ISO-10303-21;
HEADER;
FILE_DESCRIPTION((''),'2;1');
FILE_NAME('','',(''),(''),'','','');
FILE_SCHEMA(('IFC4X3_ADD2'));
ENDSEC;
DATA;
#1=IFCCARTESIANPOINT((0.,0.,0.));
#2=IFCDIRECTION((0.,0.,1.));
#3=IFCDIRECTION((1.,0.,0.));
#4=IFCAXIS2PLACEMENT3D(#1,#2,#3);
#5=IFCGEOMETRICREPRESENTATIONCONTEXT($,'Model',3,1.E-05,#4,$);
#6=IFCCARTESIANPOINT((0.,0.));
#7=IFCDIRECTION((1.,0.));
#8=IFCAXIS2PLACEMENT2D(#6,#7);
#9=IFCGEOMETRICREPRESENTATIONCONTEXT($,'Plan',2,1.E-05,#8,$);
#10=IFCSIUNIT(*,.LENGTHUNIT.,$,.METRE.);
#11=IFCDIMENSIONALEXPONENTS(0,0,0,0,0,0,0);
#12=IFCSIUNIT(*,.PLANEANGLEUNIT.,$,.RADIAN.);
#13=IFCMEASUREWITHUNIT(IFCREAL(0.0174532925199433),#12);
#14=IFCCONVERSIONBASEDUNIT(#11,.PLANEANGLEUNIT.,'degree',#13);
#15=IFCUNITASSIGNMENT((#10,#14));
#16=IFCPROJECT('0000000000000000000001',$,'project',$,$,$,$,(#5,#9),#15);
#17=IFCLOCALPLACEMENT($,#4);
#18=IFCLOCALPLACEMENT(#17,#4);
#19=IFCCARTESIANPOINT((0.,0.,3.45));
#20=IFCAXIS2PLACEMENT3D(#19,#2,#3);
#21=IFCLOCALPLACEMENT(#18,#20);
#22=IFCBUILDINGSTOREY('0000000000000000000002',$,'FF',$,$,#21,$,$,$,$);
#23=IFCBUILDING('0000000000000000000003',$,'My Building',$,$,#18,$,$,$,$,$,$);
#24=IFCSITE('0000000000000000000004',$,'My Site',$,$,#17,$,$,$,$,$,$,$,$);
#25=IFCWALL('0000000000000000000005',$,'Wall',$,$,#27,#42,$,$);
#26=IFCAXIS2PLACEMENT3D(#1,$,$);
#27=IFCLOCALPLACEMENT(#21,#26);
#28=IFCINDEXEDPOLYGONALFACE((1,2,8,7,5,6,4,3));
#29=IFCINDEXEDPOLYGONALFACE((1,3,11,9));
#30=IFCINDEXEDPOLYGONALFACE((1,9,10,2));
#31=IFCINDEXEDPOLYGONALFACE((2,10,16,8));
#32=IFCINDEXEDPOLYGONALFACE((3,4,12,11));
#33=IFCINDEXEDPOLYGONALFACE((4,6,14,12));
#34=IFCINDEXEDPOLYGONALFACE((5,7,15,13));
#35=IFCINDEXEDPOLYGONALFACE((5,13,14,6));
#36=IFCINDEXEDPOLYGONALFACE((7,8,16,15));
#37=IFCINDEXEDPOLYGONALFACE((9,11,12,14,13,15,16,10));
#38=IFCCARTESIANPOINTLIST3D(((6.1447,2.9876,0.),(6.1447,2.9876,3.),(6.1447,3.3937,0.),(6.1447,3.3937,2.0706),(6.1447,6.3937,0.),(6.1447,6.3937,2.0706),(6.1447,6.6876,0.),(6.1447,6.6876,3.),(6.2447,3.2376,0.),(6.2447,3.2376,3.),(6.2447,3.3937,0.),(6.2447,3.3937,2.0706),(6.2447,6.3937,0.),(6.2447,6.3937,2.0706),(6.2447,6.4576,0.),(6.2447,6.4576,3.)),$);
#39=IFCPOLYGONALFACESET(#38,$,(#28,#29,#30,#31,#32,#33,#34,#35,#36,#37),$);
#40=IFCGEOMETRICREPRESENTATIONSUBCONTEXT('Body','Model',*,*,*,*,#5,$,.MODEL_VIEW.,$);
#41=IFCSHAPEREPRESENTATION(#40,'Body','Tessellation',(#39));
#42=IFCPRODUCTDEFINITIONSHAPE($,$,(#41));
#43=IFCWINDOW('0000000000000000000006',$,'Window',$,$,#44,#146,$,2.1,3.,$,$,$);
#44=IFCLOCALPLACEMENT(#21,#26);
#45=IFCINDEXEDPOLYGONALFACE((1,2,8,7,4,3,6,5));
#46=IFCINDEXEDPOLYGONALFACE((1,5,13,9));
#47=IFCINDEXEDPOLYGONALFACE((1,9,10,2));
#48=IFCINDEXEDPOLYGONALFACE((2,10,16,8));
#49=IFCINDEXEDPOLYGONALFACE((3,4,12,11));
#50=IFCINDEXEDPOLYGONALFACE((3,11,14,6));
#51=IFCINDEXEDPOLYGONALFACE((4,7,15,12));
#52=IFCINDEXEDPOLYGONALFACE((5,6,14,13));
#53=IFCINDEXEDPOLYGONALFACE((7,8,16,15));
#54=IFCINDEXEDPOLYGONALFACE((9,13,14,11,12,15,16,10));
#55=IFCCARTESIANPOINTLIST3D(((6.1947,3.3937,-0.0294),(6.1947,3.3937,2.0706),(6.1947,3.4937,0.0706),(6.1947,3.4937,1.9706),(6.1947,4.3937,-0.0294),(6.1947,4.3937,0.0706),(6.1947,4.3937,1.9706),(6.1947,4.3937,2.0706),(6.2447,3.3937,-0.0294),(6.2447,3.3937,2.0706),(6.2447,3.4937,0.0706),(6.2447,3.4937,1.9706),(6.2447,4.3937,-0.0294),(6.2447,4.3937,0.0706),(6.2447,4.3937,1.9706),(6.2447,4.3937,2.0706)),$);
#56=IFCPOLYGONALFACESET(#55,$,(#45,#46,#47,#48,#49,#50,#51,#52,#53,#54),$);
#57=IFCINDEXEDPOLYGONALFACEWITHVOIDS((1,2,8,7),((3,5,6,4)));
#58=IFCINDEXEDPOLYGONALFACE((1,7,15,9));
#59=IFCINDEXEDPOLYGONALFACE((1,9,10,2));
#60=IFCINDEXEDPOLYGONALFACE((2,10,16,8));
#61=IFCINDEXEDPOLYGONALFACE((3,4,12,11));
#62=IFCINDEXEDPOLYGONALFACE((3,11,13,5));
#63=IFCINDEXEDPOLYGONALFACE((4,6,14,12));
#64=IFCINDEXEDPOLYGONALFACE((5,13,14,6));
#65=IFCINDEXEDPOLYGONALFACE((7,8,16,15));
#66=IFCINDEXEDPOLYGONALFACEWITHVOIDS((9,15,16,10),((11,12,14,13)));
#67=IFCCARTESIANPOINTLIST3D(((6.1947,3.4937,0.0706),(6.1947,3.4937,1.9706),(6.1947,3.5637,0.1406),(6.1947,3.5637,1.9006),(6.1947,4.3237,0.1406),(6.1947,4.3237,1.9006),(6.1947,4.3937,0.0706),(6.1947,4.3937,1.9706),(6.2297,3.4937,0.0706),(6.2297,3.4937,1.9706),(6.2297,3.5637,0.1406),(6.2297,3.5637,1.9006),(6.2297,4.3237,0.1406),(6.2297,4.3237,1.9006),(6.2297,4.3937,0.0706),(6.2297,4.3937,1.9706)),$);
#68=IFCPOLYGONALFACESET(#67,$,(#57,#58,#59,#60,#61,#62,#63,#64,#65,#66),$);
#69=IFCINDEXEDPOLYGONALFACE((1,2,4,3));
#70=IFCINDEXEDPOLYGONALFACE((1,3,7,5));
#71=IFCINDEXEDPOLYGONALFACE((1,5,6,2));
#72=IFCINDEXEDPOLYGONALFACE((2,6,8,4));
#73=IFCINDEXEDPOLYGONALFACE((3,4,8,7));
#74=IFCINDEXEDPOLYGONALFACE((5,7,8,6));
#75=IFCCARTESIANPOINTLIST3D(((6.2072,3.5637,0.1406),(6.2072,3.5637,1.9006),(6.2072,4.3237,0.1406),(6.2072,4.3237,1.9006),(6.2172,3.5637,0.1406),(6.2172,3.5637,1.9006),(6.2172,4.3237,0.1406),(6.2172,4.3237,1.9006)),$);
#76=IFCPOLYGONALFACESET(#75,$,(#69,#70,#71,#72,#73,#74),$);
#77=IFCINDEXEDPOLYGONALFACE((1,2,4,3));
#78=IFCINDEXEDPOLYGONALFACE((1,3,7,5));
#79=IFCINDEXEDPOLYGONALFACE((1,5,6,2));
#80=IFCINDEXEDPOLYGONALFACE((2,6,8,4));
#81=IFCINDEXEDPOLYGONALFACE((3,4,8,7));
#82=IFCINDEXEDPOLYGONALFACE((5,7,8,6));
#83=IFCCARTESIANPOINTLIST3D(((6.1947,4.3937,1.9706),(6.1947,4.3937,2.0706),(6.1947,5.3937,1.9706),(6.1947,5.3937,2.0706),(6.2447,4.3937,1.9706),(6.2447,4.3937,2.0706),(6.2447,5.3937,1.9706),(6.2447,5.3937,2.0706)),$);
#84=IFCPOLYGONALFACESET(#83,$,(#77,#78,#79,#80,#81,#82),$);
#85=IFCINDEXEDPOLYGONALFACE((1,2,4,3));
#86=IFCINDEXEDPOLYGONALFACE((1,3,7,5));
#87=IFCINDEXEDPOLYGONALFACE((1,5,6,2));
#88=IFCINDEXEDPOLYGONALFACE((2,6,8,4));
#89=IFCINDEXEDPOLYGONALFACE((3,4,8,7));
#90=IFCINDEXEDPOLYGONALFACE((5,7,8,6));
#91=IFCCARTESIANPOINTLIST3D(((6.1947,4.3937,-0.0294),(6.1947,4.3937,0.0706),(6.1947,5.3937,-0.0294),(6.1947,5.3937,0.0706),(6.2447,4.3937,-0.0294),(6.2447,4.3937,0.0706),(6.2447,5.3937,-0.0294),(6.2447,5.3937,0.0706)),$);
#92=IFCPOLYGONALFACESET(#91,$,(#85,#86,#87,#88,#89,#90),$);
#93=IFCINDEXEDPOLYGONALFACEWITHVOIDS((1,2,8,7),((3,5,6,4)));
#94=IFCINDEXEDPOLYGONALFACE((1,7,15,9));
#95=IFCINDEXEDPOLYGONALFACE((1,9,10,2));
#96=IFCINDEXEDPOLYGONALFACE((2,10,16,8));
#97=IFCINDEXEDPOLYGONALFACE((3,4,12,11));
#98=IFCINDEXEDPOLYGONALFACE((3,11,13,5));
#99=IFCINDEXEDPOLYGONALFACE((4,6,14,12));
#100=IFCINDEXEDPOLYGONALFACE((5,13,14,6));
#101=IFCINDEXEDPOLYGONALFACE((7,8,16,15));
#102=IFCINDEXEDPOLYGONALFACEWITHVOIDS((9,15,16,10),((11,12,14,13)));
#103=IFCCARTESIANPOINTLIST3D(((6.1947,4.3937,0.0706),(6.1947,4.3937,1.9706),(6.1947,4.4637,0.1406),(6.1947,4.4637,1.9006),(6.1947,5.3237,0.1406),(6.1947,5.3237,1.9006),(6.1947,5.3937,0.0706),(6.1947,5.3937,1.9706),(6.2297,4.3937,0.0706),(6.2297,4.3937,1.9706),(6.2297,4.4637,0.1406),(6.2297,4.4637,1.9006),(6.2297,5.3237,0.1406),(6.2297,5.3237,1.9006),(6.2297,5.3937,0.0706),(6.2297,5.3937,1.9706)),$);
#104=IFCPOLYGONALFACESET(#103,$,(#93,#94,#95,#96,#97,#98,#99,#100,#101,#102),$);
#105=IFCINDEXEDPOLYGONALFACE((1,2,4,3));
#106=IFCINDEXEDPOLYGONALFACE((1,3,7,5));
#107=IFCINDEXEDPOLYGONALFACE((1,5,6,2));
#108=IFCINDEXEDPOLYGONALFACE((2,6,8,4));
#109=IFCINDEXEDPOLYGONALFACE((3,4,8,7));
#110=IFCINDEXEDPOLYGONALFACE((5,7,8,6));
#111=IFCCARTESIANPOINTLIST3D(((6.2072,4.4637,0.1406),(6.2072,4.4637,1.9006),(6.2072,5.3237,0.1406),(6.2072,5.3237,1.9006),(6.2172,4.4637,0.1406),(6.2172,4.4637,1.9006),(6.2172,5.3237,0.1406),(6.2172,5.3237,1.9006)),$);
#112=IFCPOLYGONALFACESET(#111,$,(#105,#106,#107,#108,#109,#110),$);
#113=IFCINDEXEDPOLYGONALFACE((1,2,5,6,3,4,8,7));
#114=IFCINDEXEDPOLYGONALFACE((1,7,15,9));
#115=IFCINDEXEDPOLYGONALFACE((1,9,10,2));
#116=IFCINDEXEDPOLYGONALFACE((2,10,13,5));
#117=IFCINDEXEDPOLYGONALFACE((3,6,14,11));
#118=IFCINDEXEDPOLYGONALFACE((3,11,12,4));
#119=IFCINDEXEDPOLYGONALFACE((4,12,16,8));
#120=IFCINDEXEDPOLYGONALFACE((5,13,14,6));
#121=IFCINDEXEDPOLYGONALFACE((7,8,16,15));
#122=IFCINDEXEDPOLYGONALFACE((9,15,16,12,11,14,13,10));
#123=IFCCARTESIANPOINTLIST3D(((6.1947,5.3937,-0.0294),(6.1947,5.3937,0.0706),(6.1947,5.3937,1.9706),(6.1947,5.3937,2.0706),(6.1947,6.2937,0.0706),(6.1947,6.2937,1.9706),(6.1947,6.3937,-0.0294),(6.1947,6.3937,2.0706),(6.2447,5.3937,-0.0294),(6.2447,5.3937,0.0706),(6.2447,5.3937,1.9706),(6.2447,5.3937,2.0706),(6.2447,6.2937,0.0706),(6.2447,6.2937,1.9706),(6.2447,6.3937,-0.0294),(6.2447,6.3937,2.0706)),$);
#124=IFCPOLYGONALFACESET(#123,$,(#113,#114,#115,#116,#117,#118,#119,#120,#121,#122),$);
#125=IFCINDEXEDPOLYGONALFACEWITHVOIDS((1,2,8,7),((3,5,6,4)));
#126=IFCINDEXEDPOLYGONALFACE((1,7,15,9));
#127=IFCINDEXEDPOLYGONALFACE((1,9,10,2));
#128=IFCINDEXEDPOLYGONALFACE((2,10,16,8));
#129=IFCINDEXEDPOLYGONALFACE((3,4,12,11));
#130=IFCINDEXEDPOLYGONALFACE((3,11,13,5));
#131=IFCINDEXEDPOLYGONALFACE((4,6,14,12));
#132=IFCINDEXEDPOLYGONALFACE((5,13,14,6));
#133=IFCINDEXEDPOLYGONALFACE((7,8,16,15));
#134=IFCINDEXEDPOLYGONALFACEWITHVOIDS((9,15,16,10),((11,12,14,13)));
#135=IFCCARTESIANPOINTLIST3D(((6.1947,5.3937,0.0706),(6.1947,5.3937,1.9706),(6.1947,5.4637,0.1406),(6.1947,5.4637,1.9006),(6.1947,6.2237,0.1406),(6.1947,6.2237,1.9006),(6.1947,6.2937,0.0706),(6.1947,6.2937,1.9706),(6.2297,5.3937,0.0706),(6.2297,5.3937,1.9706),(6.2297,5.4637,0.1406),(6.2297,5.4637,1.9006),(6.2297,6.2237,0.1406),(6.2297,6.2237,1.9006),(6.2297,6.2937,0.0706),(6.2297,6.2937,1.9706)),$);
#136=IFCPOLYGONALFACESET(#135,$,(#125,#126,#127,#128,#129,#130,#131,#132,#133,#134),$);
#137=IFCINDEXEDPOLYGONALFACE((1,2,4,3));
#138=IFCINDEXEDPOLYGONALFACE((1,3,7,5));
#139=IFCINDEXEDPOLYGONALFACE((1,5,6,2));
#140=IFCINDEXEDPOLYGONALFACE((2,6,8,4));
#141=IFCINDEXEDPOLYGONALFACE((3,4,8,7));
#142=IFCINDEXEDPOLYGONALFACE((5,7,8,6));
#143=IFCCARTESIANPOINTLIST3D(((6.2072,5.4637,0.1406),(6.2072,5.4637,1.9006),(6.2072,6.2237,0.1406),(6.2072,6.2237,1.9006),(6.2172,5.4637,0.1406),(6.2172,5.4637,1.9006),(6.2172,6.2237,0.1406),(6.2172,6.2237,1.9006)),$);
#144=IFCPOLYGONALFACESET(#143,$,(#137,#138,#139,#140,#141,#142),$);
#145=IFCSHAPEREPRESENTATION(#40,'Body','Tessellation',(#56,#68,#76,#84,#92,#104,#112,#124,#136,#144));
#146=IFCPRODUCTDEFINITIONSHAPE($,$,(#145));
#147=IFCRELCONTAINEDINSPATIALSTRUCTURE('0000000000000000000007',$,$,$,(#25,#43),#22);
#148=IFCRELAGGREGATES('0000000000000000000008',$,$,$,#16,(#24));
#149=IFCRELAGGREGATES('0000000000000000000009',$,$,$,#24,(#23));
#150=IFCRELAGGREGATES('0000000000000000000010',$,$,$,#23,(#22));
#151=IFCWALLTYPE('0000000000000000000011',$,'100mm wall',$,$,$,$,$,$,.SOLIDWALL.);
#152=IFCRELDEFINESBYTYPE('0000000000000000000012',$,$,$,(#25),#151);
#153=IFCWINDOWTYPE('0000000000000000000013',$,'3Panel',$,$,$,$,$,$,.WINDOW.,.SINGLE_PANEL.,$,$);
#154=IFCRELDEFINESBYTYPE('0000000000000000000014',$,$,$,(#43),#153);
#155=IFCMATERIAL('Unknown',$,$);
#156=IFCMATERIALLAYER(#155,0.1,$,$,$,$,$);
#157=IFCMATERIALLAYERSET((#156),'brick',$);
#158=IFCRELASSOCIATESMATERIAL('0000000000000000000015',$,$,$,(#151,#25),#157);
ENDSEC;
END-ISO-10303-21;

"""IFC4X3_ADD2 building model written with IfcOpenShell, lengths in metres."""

from ifc_helpers import new_model, entity, si_unit, converted_unit, frame, origin_with_axes, origin_2d_with_axis, place, context, subcontext, project, spatial, line, indexed_curve, outline, extrude, shape, source, transform, mapped, material, layer, layer_set, layer_usage, type_object, type_shapes, element, fill, save


model = new_model("IFC4X3_ADD2")

# Units and contexts
model_context = context("Model", 3, precision=1e-05, world=origin_with_axes())
plan_context = context("Plan", 2, precision=1e-05, world=origin_2d_with_axis())
body_context_1 = subcontext(model_context, "Body", "Model", "MODEL_VIEW")
body_context_2 = subcontext(plan_context, "Body", "Plan", "PLAN_VIEW")
ifc_project = project(units=[si_unit("LENGTHUNIT", "METRE"), converted_unit("PLANEANGLEUNIT", "degree", entity("IfcReal", 0.0174532925199433), si_unit("PLANEANGLEUNIT", "RADIAN"), dimensions=[0, 0, 0, 0, 0, 0, 0])], contexts=[model_context, plan_context])

# Site, building, storey
site_placement = place(None, origin_with_axes())
site = spatial("IfcSite", under=ifc_project, at=site_placement, Name="My Site")
building_placement = place(site_placement, origin_with_axes())
building = spatial("IfcBuilding", under=site, at=building_placement, Name="My Building")
storey_placement = place(building_placement, frame((0.0, 0.0, 3.45), z_axis=(0.0, 0.0, 1.0), x_axis=(1.0, 0.0, 0.0)))
storey = spatial("IfcBuildingStorey", under=building, at=storey_placement, Name="FF")

# Shared definitions
ifc_material = material(Name="Unknown")

# Shared definitions
ifc_layer_1 = layer(ifc_material, 0.1)
ifc_layer_set_1 = layer_set([ifc_layer_1], Name="brick")
wall_type_1 = type_object("IfcWallType", Name="100mm wall", PredefinedType="SOLIDWALL", material=ifc_layer_set_1)

# Wall, opening, window
ifc_layer_usage_1 = layer_usage(ifc_layer_set_1, "AXIS2", "POSITIVE", 0.0)
wall_1_placement = place(storey_placement, frame((6.2447, 2.9876, 0.0), z_axis=(0.0, 0.0, 1.0), x_axis=(0.0, 1.0, 0.0)))
wall_1 = element("IfcWall", 1, at=wall_1_placement, inside=storey, type_object=wall_type_1, material=ifc_layer_usage_1, Name="Wall", context=body_context_1, shape_type="SweptSolid", body=[
    extrude(outline(indexed_curve([(0.25, 0.0), (0.0, 0.1), (3.7, 0.1), (3.47, 0.0)], segments=[line(1, 2, 3, 4, 1)])), origin_with_axes(), (0.0, 0.0, 1.0), 3.0),
])
shared_shape_1 = source(origin_with_axes(), body_context_1, "Body", "SweptSolid", [
    extrude(outline(indexed_curve([(0.0, 0.0), (3.0, 0.0), (3.0, 2.1), (0.0, 2.1)], segments=[line(1, 2, 3, 4, 1)])), frame((0.0, -0.6, 0.0), z_axis=(0.0, -1.0, 0.0), x_axis=(1.0, 0.0, 0.0)), (0.0, 0.0, -1.0), 1.2),
])
opening_1_placement = place(wall_1_placement, frame((0.4061, 0.0, -0.0294), z_axis=(0.0, 0.0, 1.0), x_axis=(1.0, 0.0, 0.0)))
opening_1 = element("IfcOpeningElement", 2, at=opening_1_placement, cuts=wall_1, PredefinedType="OPENING", context=body_context_1, shape_type="MappedRepresentation", body=[
    mapped(shared_shape_1, transform((0.0, 0.0, 0.0), x_axis=(1.0, 0.0, 0.0), y_axis=(0.0, 1.0, 0.0), z_axis=(0.0, 0.0, 1.0), scale=1.0)),
])
window_type = type_object("IfcWindowType", Name="3Panel", PartitioningType="SINGLE_PANEL", PredefinedType="WINDOW")
shared_shape_2 = source(origin_with_axes(), body_context_1, "Body", "SweptSolid", [
    extrude(outline(indexed_curve([(1.0, 0.0), (0.0, 0.0), (0.0, 2.1), (1.0, 2.1), (1.0, 2.0), (0.1, 2.0), (0.1, 0.1), (1.0, 0.1)], segments=[line(1, 2, 3, 4, 5, 6, 7, 8, 1)])), frame((0.0, 0.0, 0.0), z_axis=(0.0, -1.0, 0.0), x_axis=(1.0, 0.0, 0.0)), (0.0, 0.0, -1.0), 0.05),
    extrude(outline(indexed_curve([(0.0, 0.0), (0.9, 0.0), (0.9, 1.9), (0.0, 1.9)], segments=[line(1, 2, 3, 4, 1)]), holes=[indexed_curve([(0.07, 0.07), (0.83, 0.07), (0.83, 1.83), (0.07, 1.83)], segments=[line(1, 2, 3, 4, 1)])]), frame((0.1, 0.015, 0.1), z_axis=(0.0, -1.0, 0.0), x_axis=(1.0, 0.0, 0.0)), (0.0, 0.0, -1.0), 0.035),
    extrude(outline(indexed_curve([(0.07, 0.07), (0.83, 0.07), (0.83, 1.83), (0.07, 1.83)], segments=[line(1, 2, 3, 4, 1)])), frame((0.1, 0.0275, 0.1), z_axis=(0.0, -1.0, 0.0), x_axis=(1.0, 0.0, 0.0)), (0.0, 0.0, -1.0), 0.01),
    extrude(outline(indexed_curve([(0.0, 2.1), (1.0, 2.1), (1.0, 2.0), (0.0, 2.0)], segments=[line(1, 2, 3, 4, 1)])), frame((1.0, 0.0, 0.0), z_axis=(0.0, -1.0, 0.0), x_axis=(1.0, 0.0, 0.0)), (0.0, 0.0, -1.0), 0.05),
    extrude(outline(indexed_curve([(1.0, 0.0), (0.0, 0.0), (0.0, 0.1), (1.0, 0.1)], segments=[line(1, 2, 3, 4, 1)])), frame((1.0, 0.0, 0.0), z_axis=(0.0, -1.0, 0.0), x_axis=(1.0, 0.0, 0.0)), (0.0, 0.0, -1.0), 0.05),
    extrude(outline(indexed_curve([(0.0, 0.0), (1.0, 0.0), (1.0, 1.9), (0.0, 1.9)], segments=[line(1, 2, 3, 4, 1)]), holes=[indexed_curve([(0.07, 0.07), (0.93, 0.07), (0.93, 1.83), (0.07, 1.83)], segments=[line(1, 2, 3, 4, 1)])]), frame((1.0, 0.015, 0.1), z_axis=(0.0, -1.0, 0.0), x_axis=(1.0, 0.0, 0.0)), (0.0, 0.0, -1.0), 0.035),
    extrude(outline(indexed_curve([(0.07, 0.07), (0.93, 0.07), (0.93, 1.83), (0.07, 1.83)], segments=[line(1, 2, 3, 4, 1)])), frame((1.0, 0.0275, 0.1), z_axis=(0.0, -1.0, 0.0), x_axis=(1.0, 0.0, 0.0)), (0.0, 0.0, -1.0), 0.01),
    extrude(outline(indexed_curve([(0.0, 2.1), (1.0, 2.1), (1.0, 0.0), (0.0, 0.0), (0.0, 0.1), (0.9, 0.1), (0.9, 2.0), (0.0, 2.0)], segments=[line(1, 2, 3, 4, 5, 6, 7, 8, 1)])), frame((2.0, 0.0, 0.0), z_axis=(0.0, -1.0, 0.0), x_axis=(1.0, 0.0, 0.0)), (0.0, 0.0, -1.0), 0.05),
    extrude(outline(indexed_curve([(0.0, 0.0), (0.9, 0.0), (0.9, 1.9), (0.0, 1.9)], segments=[line(1, 2, 3, 4, 1)]), holes=[indexed_curve([(0.07, 0.07), (0.83, 0.07), (0.83, 1.83), (0.07, 1.83)], segments=[line(1, 2, 3, 4, 1)])]), frame((2.0, 0.015, 0.1), z_axis=(0.0, -1.0, 0.0), x_axis=(1.0, 0.0, 0.0)), (0.0, 0.0, -1.0), 0.035),
    extrude(outline(indexed_curve([(0.07, 0.07), (0.83, 0.07), (0.83, 1.83), (0.07, 1.83)], segments=[line(1, 2, 3, 4, 1)])), frame((2.0, 0.0275, 0.1), z_axis=(0.0, -1.0, 0.0), x_axis=(1.0, 0.0, 0.0)), (0.0, 0.0, -1.0), 0.01),
])
shared_shape_3 = source(origin_with_axes(), body_context_2, "Body", "Curve2D", [
    entity("IfcIndexedPolyCurve", entity("IfcCartesianPointList2D", [[0.1, 0.0], [1.0, 0.0]])),
    entity("IfcIndexedPolyCurve", entity("IfcCartesianPointList2D", [[0.0, 0.05], [0.1, 0.05], [0.1, 0.0], [0.0, 0.0]]), [entity("IfcLineIndex", [1, 2, 3, 4, 1])]),
    entity("IfcIndexedPolyCurve", entity("IfcCartesianPointList2D", [[1.0, 0.05], [1.0, 0.05], [1.0, 0.0], [1.0, 0.0]])),
    entity("IfcIndexedPolyCurve", entity("IfcCartesianPointList2D", [[0.1, 0.015], [0.17, 0.015], [0.17, 0.05], [0.1, 0.05]]), [entity("IfcLineIndex", [1, 2, 3, 4, 1])]),
    entity("IfcIndexedPolyCurve", entity("IfcCartesianPointList2D", [[1.0, 0.015], [0.93, 0.015], [0.93, 0.05], [1.0, 0.05]]), [entity("IfcLineIndex", [1, 2, 3, 4, 1])]),
    entity("IfcIndexedPolyCurve", entity("IfcCartesianPointList2D", [[0.17, 0.015], [0.93, 0.015]])),
    entity("IfcIndexedPolyCurve", entity("IfcCartesianPointList2D", [[0.17, 0.05], [0.93, 0.05]])),
    entity("IfcIndexedPolyCurve", entity("IfcCartesianPointList2D", [[0.17, 0.0325], [0.93, 0.0325]])),
    entity("IfcIndexedPolyCurve", entity("IfcCartesianPointList2D", [[1.0, 0.0], [2.0, 0.0]])),
    entity("IfcIndexedPolyCurve", entity("IfcCartesianPointList2D", [[1.0, 0.05], [1.0, 0.05], [1.0, 0.0], [1.0, 0.0]])),
    entity("IfcIndexedPolyCurve", entity("IfcCartesianPointList2D", [[2.0, 0.05], [2.0, 0.05], [2.0, 0.0], [2.0, 0.0]])),
    entity("IfcIndexedPolyCurve", entity("IfcCartesianPointList2D", [[1.0, 0.015], [1.07, 0.015], [1.07, 0.05], [1.0, 0.05]]), [entity("IfcLineIndex", [1, 2, 3, 4, 1])]),
    entity("IfcIndexedPolyCurve", entity("IfcCartesianPointList2D", [[2.0, 0.015], [1.93, 0.015], [1.93, 0.05], [2.0, 0.05]]), [entity("IfcLineIndex", [1, 2, 3, 4, 1])]),
    entity("IfcIndexedPolyCurve", entity("IfcCartesianPointList2D", [[1.07, 0.015], [1.93, 0.015]])),
    entity("IfcIndexedPolyCurve", entity("IfcCartesianPointList2D", [[1.07, 0.05], [1.93, 0.05]])),
    entity("IfcIndexedPolyCurve", entity("IfcCartesianPointList2D", [[1.07, 0.0325], [1.93, 0.0325]])),
    entity("IfcIndexedPolyCurve", entity("IfcCartesianPointList2D", [[2.0, 0.0], [2.9, 0.0]])),
    entity("IfcIndexedPolyCurve", entity("IfcCartesianPointList2D", [[2.0, 0.05], [2.0, 0.05], [2.0, 0.0], [2.0, 0.0]])),
    entity("IfcIndexedPolyCurve", entity("IfcCartesianPointList2D", [[3.0, 0.05], [2.9, 0.05], [2.9, 0.0], [3.0, 0.0]]), [entity("IfcLineIndex", [1, 2, 3, 4, 1])]),
    entity("IfcIndexedPolyCurve", entity("IfcCartesianPointList2D", [[2.0, 0.015], [2.07, 0.015], [2.07, 0.05], [2.0, 0.05]]), [entity("IfcLineIndex", [1, 2, 3, 4, 1])]),
    entity("IfcIndexedPolyCurve", entity("IfcCartesianPointList2D", [[2.9, 0.015], [2.83, 0.015], [2.83, 0.05], [2.9, 0.05]]), [entity("IfcLineIndex", [1, 2, 3, 4, 1])]),
    entity("IfcIndexedPolyCurve", entity("IfcCartesianPointList2D", [[2.07, 0.015], [2.83, 0.015]])),
    entity("IfcIndexedPolyCurve", entity("IfcCartesianPointList2D", [[2.07, 0.05], [2.83, 0.05]])),
    entity("IfcIndexedPolyCurve", entity("IfcCartesianPointList2D", [[2.07, 0.0325], [2.83, 0.0325]])),
])
type_shapes(window_type, [shared_shape_2, shared_shape_3])
window_placement = place(opening_1_placement, frame((0.0, 0.0, 0.0), z_axis=(0.0, 0.0, 1.0), x_axis=(1.0, 0.0, 0.0)))
window = element("IfcWindow", 3, at=window_placement, inside=storey, type_object=window_type, Name="Window", OverallHeight=2.1, OverallWidth=3.0, shapes=[
    shape(body_context_1, "Body", "MappedRepresentation", [mapped(shared_shape_2, transform((0.0, 0.0, 0.0), x_axis=(1.0, 0.0, 0.0), y_axis=(0.0, 1.0, 0.0), z_axis=(0.0, 0.0, 1.0), scale=1.0))]),
    shape(body_context_2, "Body", "MappedRepresentation", [mapped(shared_shape_3, transform((0.0, 0.0, 0.0), x_axis=(1.0, 0.0, 0.0), y_axis=(0.0, 1.0, 0.0), z_axis=(0.0, 0.0, 1.0), scale=1.0))]),
])
fill(opening_1, window)

save(model, "model.ifc")
